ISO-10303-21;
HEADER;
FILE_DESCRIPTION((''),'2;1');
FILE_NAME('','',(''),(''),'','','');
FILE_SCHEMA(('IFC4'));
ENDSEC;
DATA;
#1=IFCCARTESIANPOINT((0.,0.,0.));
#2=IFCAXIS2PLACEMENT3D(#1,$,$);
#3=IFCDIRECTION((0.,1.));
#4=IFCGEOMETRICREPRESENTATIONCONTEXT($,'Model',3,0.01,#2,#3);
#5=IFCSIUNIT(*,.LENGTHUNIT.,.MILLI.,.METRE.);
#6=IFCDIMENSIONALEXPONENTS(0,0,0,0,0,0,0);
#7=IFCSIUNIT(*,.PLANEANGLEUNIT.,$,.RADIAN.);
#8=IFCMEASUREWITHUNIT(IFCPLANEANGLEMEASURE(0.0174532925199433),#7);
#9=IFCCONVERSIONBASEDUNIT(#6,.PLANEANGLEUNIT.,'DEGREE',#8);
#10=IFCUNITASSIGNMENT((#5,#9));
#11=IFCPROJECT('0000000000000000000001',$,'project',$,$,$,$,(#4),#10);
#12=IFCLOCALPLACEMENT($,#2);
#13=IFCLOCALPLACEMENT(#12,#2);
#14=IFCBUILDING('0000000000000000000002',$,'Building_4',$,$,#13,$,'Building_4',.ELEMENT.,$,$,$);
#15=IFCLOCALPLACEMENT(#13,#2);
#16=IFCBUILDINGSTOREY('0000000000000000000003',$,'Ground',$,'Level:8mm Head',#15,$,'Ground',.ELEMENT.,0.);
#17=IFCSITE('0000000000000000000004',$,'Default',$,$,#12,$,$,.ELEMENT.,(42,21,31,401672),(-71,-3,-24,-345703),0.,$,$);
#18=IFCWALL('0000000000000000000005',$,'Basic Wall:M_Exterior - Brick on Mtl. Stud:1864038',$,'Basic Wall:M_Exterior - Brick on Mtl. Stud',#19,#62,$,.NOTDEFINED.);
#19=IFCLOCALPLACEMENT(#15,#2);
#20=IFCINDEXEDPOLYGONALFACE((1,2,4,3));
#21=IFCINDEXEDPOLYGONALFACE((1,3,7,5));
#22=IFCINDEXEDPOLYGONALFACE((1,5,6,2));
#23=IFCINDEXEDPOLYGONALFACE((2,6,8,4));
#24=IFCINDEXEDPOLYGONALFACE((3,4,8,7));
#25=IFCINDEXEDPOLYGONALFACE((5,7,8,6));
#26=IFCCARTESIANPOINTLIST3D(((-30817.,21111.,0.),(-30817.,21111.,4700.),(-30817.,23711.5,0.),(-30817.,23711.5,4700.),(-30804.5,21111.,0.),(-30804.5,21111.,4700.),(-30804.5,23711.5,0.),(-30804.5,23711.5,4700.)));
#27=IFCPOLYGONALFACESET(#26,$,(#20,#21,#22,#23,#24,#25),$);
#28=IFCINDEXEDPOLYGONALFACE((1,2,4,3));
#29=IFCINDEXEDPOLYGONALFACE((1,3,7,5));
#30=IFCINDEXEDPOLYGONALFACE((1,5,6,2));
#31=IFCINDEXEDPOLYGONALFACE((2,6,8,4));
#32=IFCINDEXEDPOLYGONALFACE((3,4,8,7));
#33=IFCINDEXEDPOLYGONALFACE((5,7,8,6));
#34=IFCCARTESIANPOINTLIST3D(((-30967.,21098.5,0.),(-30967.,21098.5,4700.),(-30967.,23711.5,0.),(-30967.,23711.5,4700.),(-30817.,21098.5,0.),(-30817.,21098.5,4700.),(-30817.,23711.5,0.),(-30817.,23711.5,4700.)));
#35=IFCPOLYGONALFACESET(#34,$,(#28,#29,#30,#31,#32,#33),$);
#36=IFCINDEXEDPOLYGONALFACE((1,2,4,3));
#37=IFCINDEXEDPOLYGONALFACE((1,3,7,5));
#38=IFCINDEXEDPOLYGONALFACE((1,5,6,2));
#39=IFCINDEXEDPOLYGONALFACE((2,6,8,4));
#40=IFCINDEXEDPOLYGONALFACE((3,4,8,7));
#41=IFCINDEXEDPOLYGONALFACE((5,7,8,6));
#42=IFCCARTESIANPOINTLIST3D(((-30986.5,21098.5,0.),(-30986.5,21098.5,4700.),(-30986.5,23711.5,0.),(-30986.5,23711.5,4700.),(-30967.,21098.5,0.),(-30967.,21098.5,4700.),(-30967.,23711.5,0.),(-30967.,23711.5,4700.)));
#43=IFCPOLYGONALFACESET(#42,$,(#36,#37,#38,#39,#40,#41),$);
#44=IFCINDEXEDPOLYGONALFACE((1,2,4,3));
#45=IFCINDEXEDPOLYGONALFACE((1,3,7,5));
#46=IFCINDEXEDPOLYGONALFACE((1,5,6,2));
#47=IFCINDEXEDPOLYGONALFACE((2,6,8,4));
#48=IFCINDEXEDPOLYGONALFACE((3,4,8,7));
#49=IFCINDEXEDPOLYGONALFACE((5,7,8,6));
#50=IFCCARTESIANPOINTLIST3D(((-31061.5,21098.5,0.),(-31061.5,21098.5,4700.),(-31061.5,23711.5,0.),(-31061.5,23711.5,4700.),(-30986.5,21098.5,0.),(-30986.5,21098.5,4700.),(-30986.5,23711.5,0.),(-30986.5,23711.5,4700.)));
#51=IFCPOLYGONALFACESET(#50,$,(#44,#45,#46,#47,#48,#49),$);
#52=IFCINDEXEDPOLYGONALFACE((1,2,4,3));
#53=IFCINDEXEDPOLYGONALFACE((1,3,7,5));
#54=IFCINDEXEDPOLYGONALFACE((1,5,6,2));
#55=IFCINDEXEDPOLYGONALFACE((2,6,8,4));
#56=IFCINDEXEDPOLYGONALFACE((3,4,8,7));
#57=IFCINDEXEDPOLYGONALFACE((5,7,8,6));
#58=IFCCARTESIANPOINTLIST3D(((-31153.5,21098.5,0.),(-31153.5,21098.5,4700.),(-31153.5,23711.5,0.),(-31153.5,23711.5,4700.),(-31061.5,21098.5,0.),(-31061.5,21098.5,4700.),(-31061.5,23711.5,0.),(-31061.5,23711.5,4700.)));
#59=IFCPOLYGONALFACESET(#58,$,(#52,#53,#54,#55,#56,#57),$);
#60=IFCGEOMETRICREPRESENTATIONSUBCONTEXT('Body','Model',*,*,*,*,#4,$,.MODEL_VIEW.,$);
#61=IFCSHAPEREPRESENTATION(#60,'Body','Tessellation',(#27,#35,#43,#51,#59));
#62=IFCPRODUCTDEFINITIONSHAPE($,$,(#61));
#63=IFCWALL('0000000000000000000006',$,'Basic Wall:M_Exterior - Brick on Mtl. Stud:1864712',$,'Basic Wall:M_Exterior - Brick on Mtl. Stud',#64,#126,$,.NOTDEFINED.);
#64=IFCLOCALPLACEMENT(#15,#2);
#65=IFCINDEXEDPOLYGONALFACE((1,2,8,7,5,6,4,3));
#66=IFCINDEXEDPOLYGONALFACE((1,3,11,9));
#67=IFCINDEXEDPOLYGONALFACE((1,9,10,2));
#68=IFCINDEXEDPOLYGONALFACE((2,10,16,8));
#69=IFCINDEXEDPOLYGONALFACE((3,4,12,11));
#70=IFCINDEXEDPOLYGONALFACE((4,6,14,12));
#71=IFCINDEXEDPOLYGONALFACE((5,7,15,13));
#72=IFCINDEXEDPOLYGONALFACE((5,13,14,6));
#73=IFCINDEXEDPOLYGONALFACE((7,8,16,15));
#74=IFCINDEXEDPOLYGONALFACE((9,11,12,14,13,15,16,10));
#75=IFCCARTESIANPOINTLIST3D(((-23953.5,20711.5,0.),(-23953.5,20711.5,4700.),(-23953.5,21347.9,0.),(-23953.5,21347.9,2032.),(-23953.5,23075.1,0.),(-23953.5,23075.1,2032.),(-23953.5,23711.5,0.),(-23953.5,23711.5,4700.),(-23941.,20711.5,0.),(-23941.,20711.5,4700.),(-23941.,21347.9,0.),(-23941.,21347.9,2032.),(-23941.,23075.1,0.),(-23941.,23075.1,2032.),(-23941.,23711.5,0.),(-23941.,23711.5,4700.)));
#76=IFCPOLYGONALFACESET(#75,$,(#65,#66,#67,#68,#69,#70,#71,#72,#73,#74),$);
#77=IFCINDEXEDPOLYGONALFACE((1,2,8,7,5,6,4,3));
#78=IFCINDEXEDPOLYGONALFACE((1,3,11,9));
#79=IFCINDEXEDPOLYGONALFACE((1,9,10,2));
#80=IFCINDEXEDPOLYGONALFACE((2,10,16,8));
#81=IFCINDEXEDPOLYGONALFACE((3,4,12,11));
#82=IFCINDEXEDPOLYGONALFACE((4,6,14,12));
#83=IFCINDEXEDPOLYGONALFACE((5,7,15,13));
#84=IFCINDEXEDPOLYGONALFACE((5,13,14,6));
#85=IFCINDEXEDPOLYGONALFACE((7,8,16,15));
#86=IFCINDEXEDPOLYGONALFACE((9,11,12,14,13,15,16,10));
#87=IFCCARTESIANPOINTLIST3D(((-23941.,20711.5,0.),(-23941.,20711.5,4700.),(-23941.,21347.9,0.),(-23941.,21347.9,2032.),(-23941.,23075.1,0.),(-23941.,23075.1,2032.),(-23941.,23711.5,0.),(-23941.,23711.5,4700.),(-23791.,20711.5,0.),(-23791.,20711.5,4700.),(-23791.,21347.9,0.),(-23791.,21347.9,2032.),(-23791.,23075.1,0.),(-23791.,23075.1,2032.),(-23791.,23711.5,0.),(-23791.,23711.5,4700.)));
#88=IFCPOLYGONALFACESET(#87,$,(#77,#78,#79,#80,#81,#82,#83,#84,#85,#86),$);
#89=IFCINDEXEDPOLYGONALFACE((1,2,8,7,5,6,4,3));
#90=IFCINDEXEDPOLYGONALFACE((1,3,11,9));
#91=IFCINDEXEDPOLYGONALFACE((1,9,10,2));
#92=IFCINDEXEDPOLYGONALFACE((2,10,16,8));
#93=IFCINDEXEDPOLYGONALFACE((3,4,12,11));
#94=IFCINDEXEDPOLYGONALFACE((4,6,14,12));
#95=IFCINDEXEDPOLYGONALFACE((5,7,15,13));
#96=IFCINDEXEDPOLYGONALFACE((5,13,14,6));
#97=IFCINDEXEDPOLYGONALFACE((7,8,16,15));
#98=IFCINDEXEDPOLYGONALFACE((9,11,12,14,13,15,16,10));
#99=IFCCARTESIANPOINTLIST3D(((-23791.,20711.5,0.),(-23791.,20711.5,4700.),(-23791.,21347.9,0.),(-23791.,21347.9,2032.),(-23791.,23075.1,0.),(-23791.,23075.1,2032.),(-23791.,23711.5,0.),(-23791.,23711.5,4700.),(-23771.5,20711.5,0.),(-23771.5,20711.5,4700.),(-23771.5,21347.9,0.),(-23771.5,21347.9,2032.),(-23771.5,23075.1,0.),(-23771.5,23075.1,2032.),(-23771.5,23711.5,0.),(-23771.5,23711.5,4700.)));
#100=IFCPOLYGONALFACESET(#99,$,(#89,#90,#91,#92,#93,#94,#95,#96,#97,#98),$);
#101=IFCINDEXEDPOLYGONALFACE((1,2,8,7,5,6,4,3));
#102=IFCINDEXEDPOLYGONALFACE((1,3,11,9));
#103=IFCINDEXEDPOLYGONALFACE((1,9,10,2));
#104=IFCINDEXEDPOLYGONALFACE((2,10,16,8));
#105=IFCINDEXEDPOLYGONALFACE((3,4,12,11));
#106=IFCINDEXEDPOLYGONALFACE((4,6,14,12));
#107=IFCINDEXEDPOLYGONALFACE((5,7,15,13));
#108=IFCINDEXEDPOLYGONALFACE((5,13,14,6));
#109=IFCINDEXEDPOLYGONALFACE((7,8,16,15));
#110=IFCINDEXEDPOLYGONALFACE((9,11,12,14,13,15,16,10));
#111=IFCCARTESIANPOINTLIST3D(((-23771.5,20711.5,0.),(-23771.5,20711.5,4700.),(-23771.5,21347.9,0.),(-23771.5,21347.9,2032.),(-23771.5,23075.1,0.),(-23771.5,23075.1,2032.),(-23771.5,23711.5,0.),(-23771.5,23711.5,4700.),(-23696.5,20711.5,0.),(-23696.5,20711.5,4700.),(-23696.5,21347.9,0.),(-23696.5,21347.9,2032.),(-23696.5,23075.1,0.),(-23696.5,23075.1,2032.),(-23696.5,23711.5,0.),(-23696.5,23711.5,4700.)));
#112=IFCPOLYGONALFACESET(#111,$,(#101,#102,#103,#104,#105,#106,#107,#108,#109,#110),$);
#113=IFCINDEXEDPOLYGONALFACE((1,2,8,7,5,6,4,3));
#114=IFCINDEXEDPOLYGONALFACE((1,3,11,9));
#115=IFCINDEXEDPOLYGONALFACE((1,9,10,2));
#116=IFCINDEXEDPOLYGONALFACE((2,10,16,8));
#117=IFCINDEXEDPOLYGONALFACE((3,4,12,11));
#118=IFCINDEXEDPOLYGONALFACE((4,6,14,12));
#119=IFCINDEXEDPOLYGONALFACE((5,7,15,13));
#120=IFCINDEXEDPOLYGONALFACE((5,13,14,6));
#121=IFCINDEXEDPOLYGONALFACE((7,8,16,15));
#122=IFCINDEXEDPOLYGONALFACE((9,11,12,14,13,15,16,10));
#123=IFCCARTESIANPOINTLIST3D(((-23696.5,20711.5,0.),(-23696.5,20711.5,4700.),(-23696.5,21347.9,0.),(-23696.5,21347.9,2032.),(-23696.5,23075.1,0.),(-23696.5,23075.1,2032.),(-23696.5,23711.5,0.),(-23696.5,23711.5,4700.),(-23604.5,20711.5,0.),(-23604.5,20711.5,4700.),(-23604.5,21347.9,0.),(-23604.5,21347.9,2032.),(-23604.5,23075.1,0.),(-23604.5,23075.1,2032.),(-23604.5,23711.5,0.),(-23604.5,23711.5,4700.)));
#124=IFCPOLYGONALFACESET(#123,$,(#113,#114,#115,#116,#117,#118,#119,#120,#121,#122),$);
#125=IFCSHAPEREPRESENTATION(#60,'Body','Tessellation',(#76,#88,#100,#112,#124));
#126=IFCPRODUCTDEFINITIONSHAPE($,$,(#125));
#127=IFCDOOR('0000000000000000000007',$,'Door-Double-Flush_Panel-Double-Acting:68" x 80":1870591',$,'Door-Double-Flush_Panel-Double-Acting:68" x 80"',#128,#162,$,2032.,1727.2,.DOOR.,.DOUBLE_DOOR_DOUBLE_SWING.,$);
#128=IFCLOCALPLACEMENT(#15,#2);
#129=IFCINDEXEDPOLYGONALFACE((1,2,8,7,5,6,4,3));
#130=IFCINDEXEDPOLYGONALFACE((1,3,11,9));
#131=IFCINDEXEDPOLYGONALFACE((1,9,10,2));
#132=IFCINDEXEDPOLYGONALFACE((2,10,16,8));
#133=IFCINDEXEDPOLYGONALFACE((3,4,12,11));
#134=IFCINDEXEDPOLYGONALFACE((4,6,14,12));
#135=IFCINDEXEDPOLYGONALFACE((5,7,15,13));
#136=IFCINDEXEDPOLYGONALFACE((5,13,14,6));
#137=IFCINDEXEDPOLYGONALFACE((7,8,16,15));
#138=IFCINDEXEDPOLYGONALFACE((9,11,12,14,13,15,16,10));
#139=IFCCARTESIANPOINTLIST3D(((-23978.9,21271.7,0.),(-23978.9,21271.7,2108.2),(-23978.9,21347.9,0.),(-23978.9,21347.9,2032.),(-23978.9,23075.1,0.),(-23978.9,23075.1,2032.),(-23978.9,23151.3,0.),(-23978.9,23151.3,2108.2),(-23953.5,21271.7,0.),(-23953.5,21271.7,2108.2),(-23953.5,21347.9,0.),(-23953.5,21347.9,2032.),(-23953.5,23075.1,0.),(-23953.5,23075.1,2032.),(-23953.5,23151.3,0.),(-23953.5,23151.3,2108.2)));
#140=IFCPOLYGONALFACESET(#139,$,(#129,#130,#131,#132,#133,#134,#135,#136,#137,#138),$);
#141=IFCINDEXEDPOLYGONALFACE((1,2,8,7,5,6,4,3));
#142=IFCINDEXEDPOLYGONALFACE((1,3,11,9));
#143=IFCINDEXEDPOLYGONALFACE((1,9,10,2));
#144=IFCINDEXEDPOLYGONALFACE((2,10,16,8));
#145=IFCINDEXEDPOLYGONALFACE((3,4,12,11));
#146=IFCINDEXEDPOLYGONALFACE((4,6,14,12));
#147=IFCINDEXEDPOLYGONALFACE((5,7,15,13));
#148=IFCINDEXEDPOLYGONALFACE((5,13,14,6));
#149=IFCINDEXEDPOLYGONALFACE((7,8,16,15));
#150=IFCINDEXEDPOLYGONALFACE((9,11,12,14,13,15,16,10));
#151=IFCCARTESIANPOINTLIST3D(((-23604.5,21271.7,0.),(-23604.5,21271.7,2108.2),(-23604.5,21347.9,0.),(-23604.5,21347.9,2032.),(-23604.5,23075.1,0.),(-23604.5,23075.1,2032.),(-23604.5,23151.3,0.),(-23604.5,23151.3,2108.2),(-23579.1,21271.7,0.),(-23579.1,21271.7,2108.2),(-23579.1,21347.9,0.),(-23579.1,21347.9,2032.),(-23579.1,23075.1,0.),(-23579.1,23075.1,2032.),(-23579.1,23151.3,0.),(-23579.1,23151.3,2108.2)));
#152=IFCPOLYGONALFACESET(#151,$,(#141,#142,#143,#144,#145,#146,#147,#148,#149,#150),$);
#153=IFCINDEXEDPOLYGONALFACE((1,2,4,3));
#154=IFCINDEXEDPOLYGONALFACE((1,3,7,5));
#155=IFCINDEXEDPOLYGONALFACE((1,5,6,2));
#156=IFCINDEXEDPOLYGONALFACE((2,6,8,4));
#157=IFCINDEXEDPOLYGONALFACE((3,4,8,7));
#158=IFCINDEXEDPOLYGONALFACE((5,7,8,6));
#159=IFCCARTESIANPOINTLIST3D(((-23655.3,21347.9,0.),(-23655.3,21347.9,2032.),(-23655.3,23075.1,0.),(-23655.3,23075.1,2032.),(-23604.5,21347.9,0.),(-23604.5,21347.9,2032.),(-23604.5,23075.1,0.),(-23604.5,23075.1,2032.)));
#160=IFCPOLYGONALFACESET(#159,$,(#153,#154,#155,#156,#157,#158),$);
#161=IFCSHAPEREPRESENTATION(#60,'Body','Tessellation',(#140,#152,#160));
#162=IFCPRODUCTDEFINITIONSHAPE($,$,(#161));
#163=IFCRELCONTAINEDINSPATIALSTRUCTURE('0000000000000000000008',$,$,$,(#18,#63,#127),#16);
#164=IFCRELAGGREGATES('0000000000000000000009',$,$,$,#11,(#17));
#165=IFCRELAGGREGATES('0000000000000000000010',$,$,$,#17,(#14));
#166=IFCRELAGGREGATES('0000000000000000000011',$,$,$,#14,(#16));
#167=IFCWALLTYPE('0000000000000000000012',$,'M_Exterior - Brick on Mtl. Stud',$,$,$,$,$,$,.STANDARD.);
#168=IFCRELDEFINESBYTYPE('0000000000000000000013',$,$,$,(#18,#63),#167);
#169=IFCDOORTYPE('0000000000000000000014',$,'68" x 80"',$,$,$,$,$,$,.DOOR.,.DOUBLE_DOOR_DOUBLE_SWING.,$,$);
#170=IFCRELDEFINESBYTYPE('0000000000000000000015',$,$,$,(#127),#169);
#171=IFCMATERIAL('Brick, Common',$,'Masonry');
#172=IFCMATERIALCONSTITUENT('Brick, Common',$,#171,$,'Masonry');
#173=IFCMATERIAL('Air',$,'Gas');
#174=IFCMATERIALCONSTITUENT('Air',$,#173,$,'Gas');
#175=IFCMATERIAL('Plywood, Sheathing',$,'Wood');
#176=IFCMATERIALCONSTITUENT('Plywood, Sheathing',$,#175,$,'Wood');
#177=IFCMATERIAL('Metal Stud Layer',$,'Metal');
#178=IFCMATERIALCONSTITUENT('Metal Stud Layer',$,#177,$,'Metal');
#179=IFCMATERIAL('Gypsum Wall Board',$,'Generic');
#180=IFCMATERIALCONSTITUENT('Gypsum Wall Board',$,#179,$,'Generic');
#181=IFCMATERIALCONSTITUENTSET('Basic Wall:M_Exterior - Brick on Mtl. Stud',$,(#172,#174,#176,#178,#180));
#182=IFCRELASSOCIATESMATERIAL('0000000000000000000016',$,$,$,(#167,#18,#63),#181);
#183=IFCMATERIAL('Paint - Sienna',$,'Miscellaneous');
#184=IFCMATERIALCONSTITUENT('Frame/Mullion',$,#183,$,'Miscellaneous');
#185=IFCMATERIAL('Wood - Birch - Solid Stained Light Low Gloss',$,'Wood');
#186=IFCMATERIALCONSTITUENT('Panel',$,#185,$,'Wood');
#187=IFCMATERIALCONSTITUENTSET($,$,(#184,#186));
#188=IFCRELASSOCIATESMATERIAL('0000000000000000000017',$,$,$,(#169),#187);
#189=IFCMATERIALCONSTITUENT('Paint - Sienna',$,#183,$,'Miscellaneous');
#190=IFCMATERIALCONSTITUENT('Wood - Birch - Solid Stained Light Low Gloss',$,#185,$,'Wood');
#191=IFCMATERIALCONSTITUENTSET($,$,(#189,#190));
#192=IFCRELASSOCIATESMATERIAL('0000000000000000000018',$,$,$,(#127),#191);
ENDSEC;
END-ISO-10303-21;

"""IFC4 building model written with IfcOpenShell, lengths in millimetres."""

from ifc_helpers import new_model, entity, si_unit, converted_unit, direction, frame, origin, place, context, subcontext, project, spatial, indexed_curve, outline, extrude, source, transform, mapped, material, constituent, constituent_set, type_object, type_shapes, element, fill, save


model = new_model("IFC4")

# Units and contexts
model_context = context("Model", 3, precision=0.01, world=origin(), true_north=direction((0.0, 1.0)))
body_context = subcontext(model_context, "Body", "Model", "MODEL_VIEW")
ifc_project = project(units=[si_unit("LENGTHUNIT", "METRE", prefix="MILLI"), converted_unit("PLANEANGLEUNIT", "DEGREE", entity("IfcPlaneAngleMeasure", 0.0174532925199433), si_unit("PLANEANGLEUNIT", "RADIAN"), dimensions=[0, 0, 0, 0, 0, 0, 0])], contexts=[model_context])

# Site, building, storey
site_placement = place(None, origin())
site = spatial("IfcSite", under=ifc_project, at=site_placement, Name="Default", CompositionType="ELEMENT", RefLatitude=(42, 21, 31, 401672), RefLongitude=(-71, -3, -24, -345703), RefElevation=0.0)
building_placement = place(site_placement, origin())
building = spatial("IfcBuilding", under=site, at=building_placement, Name="Building_4", LongName="Building_4", CompositionType="ELEMENT")
storey_placement = place(building_placement, origin())
storey = spatial("IfcBuildingStorey", under=building, at=storey_placement, Name="Ground", ObjectType="Level:8mm Head", LongName="Ground", CompositionType="ELEMENT", Elevation=0.0)

# Shared definitions
ifc_material_1 = material(Name="Brick, Common", Category="Masonry")
ifc_constituent_1 = constituent(ifc_material_1, Name="Brick, Common", Category="Masonry")
ifc_material_2 = material(Name="Air", Category="Gas")
ifc_constituent_2 = constituent(ifc_material_2, Name="Air", Category="Gas")
ifc_material_3 = material(Name="Plywood, Sheathing", Category="Wood")
ifc_constituent_3 = constituent(ifc_material_3, Name="Plywood, Sheathing", Category="Wood")
ifc_material_4 = material(Name="Metal Stud Layer", Category="Metal")
ifc_constituent_4 = constituent(ifc_material_4, Name="Metal Stud Layer", Category="Metal")
ifc_material_5 = material(Name="Gypsum Wall Board", Category="Generic")
ifc_constituent_5 = constituent(ifc_material_5, Name="Gypsum Wall Board", Category="Generic")
ifc_constituent_set_1 = constituent_set(constituents=[ifc_constituent_1, ifc_constituent_2, ifc_constituent_3, ifc_constituent_4, ifc_constituent_5], Name="Basic Wall:M_Exterior - Brick on Mtl. Stud")
wall_type_1 = type_object("IfcWallType", Name="M_Exterior - Brick on Mtl. Stud", PredefinedType="STANDARD", material=ifc_constituent_set_1)

# Wall
wall_1_placement = place(storey_placement, frame((-30979.0, 21111.0, 0.0), z_axis=(0.0, 0.0, 1.0), x_axis=(0.0, 1.0, 0.0)))
element("IfcWall", 1, at=wall_1_placement, inside=storey, type_object=wall_type_1, material=ifc_constituent_set_1, Name="Basic Wall:M_Exterior - Brick on Mtl. Stud:1864038", ObjectType="Basic Wall:M_Exterior - Brick on Mtl. Stud", PredefinedType="NOTDEFINED", context=body_context, shape_type="SweptSolid", body=[
    extrude(outline(indexed_curve([(-6.3, -1300.2), (6.2, -1300.2), (6.2, 1300.2), (-6.2, 1300.2), (-6.3, -1300.2)], self_intersect=False)), frame((1300.2, -168.2, 0.0), z_axis=(0.0, 0.0, 1.0), x_axis=(0.0, 1.0, 0.0)), (0.0, 0.0, 1.0), 4700.0),
    extrude(outline(indexed_curve([(-1306.5, -75.0), (1306.5, -75.0), (1306.5, 75.0), (-1306.5, 75.0), (-1306.5, -75.0)], self_intersect=False)), frame((1294.0, -87.0, 0.0)), (0.0, 0.0, 1.0), 4700.0),
    extrude(outline(indexed_curve([(-1306.5, -9.7), (1306.5, -9.7), (1306.5, 9.7), (-1306.5, 9.7), (-1306.5, -9.7)], self_intersect=False)), frame((1294.0, -2.3, 0.0)), (0.0, 0.0, 1.0), 4700.0),
    extrude(outline(indexed_curve([(-1306.5, -37.5), (1306.5, -37.5), (1306.5, 37.5), (-1306.5, 37.5), (-1306.5, -37.5)], self_intersect=False)), frame((1294.0, 45.0, 0.0)), (0.0, 0.0, 1.0), 4700.0),
    extrude(outline(indexed_curve([(-46.0, -1306.5), (46.0, -1306.5), (46.0, 1306.5), (-46.0, 1306.5), (-46.0, -1306.5)], self_intersect=False)), frame((1294.0, 128.5, 0.0), z_axis=(0.0, 0.0, 1.0), x_axis=(0.0, -1.0, 0.0)), (0.0, 0.0, 1.0), 4700.0),
])

# Wall, opening, door
wall_2_placement = place(storey_placement, frame((-23779.0, 23711.5, 0.0), z_axis=(0.0, 0.0, 1.0), x_axis=(0.0, -1.0, 0.0)))
wall_2 = element("IfcWall", 2, at=wall_2_placement, inside=storey, type_object=wall_type_1, material=ifc_constituent_set_1, Name="Basic Wall:M_Exterior - Brick on Mtl. Stud:1864712", ObjectType="Basic Wall:M_Exterior - Brick on Mtl. Stud", PredefinedType="NOTDEFINED", context=body_context, shape_type="SweptSolid", body=[
    extrude(outline(indexed_curve([(-1500.0, -1683.0), (-863.6, -1683.0), (-863.6, 349.0), (863.6, 349.0), (863.6, -1683.0), (1500.0, -1683.0), (1500.0, 3017.0), (-1500.0, 3017.0), (-1500.0, -1683.0)], self_intersect=False)), frame((1500.0, -174.5, 1683.0), z_axis=(0.0, 1.0, 0.0), x_axis=(-1.0, 0.0, 0.0)), (0.0, 0.0, 1.0), 12.5),
    extrude(outline(indexed_curve([(-1683.0, -863.6), (-1683.0, -1500.0), (3017.0, -1500.0), (3017.0, 1500.0), (-1683.0, 1500.0), (-1683.0, 863.6), (349.0, 863.6), (349.0, -863.6), (-1683.0, -863.6)], self_intersect=False)), frame((1500.0, -162.0, 1683.0), z_axis=(0.0, -1.0, 0.0), x_axis=(0.0, 0.0, 1.0)), (0.0, 0.0, -1.0), 150.0),
    extrude(outline(indexed_curve([(-1683.0, -863.6), (-1683.0, -1500.0), (3017.0, -1500.0), (3017.0, 1500.0), (-1683.0, 1500.0), (-1683.0, 863.6), (349.0, 863.6), (349.0, -863.6), (-1683.0, -863.6)], self_intersect=False)), frame((1500.0, -12.0, 1683.0), z_axis=(0.0, -1.0, 0.0), x_axis=(0.0, 0.0, 1.0)), (0.0, 0.0, -1.0), 19.5),
    extrude(outline(indexed_curve([(-1683.0, -863.6), (-1683.0, -1500.0), (3017.0, -1500.0), (3017.0, 1500.0), (-1683.0, 1500.0), (-1683.0, 863.6), (349.0, 863.6), (349.0, -863.6), (-1683.0, -863.6)], self_intersect=False)), frame((1500.0, 7.5, 1683.0), z_axis=(0.0, -1.0, 0.0), x_axis=(0.0, 0.0, 1.0)), (0.0, 0.0, -1.0), 75.0),
    extrude(outline(indexed_curve([(-1683.0, -863.6), (-1683.0, -1500.0), (3017.0, -1500.0), (3017.0, 1500.0), (-1683.0, 1500.0), (-1683.0, 863.6), (349.0, 863.6), (349.0, -863.6), (-1683.0, -863.6)], self_intersect=False)), frame((1500.0, 82.5, 1683.0), z_axis=(0.0, -1.0, 0.0), x_axis=(0.0, 0.0, 1.0)), (0.0, 0.0, -1.0), 92.0),
])
opening_1_placement = place(wall_2_placement, frame((636.4, -174.5, 0.0)))
opening_1 = element("IfcOpeningElement", 3, at=opening_1_placement, cuts=wall_2, PredefinedType="OPENING", context=body_context, shape_type="SweptSolid", body=[
    extrude(outline(indexed_curve([(0.0, 1727.2), (0.0, 0.0), (2032.0, 0.0), (2032.0, 1727.2), (0.0, 1727.2)], self_intersect=False)), frame((0.0, 0.0, 0.0), z_axis=(0.0, 1.0, 0.0), x_axis=(0.0, 0.0, 1.0)), (0.0, 0.0, 1.0), 349.0),
])
ifc_material_6 = material(Name="Paint - Sienna", Category="Miscellaneous")
ifc_constituent_6 = constituent(ifc_material_6, Name="Paint - Sienna", Category="Miscellaneous")
ifc_material_7 = material(Name="Wood - Birch - Solid Stained Light Low Gloss", Category="Wood")
ifc_constituent_7 = constituent(ifc_material_7, Name="Wood - Birch - Solid Stained Light Low Gloss", Category="Wood")
ifc_constituent_set_2 = constituent_set(constituents=[ifc_constituent_6, ifc_constituent_7])
ifc_constituent_8 = constituent(ifc_material_6, Name="Frame/Mullion", Category="Miscellaneous")
ifc_constituent_9 = constituent(ifc_material_7, Name="Panel", Category="Wood")
ifc_constituent_set_3 = constituent_set(constituents=[ifc_constituent_8, ifc_constituent_9])
door_type = type_object("IfcDoorType", Name="68\" x 80\"", OperationType="DOUBLE_DOOR_DOUBLE_SWING", PredefinedType="DOOR", material=ifc_constituent_set_3)
shared_shape_1 = source(origin(), body_context, "Body", "SweptSolid", [
    extrude(outline(indexed_curve([(-997.0, 863.6), (1035.0, 863.6), (1035.0, 939.8), (-1073.2, 939.8), (-1073.2, -939.8), (1035.0, -939.8), (1035.0, -863.6), (-997.0, -863.6), (-997.0, 863.6)], self_intersect=False)), frame((863.6, -25.4, 1035.0), z_axis=(0.0, 1.0, 0.0), x_axis=(0.0, 0.0, -1.0)), (0.0, 0.0, 1.0), 25.4),
    extrude(outline(indexed_curve([(-939.8, -1073.2), (939.8, -1073.2), (939.8, 1035.0), (863.6, 1035.0), (863.6, -997.0), (-863.6, -997.0), (-863.6, 1035.0), (-939.8, 1035.0), (-939.8, -1073.2)], self_intersect=False)), frame((863.6, 349.0, 1035.0), z_axis=(0.0, 1.0, 0.0), x_axis=(1.0, 0.0, 0.0)), (0.0, 0.0, 1.0), 25.4),
    extrude(outline(indexed_curve([(-25.4, -863.6), (25.4, -863.6), (25.4, 863.6), (-25.4, 863.6), (-25.4, -863.6)], self_intersect=False)), frame((863.6, 323.6, 0.0), z_axis=(0.0, 0.0, 1.0), x_axis=(0.0, -1.0, 0.0)), (0.0, 0.0, 1.0), 2032.0),
])
type_shapes(door_type, [shared_shape_1])
door_placement = place(opening_1_placement, origin())
door = element("IfcDoor", 4, at=door_placement, inside=storey, type_object=door_type, material=ifc_constituent_set_2, Name="Door-Double-Flush_Panel-Double-Acting:68\" x 80\":1870591", ObjectType="Door-Double-Flush_Panel-Double-Acting:68\" x 80\"", OperationType="DOUBLE_DOOR_DOUBLE_SWING", OverallHeight=2032.0, OverallWidth=1727.2, PredefinedType="DOOR", context=body_context, shape_type="MappedRepresentation", body=[
    mapped(shared_shape_1, transform((0.0, 0.0, 0.0), scale=1.0)),
])
fill(opening_1, door)

save(model, "model.ifc")
